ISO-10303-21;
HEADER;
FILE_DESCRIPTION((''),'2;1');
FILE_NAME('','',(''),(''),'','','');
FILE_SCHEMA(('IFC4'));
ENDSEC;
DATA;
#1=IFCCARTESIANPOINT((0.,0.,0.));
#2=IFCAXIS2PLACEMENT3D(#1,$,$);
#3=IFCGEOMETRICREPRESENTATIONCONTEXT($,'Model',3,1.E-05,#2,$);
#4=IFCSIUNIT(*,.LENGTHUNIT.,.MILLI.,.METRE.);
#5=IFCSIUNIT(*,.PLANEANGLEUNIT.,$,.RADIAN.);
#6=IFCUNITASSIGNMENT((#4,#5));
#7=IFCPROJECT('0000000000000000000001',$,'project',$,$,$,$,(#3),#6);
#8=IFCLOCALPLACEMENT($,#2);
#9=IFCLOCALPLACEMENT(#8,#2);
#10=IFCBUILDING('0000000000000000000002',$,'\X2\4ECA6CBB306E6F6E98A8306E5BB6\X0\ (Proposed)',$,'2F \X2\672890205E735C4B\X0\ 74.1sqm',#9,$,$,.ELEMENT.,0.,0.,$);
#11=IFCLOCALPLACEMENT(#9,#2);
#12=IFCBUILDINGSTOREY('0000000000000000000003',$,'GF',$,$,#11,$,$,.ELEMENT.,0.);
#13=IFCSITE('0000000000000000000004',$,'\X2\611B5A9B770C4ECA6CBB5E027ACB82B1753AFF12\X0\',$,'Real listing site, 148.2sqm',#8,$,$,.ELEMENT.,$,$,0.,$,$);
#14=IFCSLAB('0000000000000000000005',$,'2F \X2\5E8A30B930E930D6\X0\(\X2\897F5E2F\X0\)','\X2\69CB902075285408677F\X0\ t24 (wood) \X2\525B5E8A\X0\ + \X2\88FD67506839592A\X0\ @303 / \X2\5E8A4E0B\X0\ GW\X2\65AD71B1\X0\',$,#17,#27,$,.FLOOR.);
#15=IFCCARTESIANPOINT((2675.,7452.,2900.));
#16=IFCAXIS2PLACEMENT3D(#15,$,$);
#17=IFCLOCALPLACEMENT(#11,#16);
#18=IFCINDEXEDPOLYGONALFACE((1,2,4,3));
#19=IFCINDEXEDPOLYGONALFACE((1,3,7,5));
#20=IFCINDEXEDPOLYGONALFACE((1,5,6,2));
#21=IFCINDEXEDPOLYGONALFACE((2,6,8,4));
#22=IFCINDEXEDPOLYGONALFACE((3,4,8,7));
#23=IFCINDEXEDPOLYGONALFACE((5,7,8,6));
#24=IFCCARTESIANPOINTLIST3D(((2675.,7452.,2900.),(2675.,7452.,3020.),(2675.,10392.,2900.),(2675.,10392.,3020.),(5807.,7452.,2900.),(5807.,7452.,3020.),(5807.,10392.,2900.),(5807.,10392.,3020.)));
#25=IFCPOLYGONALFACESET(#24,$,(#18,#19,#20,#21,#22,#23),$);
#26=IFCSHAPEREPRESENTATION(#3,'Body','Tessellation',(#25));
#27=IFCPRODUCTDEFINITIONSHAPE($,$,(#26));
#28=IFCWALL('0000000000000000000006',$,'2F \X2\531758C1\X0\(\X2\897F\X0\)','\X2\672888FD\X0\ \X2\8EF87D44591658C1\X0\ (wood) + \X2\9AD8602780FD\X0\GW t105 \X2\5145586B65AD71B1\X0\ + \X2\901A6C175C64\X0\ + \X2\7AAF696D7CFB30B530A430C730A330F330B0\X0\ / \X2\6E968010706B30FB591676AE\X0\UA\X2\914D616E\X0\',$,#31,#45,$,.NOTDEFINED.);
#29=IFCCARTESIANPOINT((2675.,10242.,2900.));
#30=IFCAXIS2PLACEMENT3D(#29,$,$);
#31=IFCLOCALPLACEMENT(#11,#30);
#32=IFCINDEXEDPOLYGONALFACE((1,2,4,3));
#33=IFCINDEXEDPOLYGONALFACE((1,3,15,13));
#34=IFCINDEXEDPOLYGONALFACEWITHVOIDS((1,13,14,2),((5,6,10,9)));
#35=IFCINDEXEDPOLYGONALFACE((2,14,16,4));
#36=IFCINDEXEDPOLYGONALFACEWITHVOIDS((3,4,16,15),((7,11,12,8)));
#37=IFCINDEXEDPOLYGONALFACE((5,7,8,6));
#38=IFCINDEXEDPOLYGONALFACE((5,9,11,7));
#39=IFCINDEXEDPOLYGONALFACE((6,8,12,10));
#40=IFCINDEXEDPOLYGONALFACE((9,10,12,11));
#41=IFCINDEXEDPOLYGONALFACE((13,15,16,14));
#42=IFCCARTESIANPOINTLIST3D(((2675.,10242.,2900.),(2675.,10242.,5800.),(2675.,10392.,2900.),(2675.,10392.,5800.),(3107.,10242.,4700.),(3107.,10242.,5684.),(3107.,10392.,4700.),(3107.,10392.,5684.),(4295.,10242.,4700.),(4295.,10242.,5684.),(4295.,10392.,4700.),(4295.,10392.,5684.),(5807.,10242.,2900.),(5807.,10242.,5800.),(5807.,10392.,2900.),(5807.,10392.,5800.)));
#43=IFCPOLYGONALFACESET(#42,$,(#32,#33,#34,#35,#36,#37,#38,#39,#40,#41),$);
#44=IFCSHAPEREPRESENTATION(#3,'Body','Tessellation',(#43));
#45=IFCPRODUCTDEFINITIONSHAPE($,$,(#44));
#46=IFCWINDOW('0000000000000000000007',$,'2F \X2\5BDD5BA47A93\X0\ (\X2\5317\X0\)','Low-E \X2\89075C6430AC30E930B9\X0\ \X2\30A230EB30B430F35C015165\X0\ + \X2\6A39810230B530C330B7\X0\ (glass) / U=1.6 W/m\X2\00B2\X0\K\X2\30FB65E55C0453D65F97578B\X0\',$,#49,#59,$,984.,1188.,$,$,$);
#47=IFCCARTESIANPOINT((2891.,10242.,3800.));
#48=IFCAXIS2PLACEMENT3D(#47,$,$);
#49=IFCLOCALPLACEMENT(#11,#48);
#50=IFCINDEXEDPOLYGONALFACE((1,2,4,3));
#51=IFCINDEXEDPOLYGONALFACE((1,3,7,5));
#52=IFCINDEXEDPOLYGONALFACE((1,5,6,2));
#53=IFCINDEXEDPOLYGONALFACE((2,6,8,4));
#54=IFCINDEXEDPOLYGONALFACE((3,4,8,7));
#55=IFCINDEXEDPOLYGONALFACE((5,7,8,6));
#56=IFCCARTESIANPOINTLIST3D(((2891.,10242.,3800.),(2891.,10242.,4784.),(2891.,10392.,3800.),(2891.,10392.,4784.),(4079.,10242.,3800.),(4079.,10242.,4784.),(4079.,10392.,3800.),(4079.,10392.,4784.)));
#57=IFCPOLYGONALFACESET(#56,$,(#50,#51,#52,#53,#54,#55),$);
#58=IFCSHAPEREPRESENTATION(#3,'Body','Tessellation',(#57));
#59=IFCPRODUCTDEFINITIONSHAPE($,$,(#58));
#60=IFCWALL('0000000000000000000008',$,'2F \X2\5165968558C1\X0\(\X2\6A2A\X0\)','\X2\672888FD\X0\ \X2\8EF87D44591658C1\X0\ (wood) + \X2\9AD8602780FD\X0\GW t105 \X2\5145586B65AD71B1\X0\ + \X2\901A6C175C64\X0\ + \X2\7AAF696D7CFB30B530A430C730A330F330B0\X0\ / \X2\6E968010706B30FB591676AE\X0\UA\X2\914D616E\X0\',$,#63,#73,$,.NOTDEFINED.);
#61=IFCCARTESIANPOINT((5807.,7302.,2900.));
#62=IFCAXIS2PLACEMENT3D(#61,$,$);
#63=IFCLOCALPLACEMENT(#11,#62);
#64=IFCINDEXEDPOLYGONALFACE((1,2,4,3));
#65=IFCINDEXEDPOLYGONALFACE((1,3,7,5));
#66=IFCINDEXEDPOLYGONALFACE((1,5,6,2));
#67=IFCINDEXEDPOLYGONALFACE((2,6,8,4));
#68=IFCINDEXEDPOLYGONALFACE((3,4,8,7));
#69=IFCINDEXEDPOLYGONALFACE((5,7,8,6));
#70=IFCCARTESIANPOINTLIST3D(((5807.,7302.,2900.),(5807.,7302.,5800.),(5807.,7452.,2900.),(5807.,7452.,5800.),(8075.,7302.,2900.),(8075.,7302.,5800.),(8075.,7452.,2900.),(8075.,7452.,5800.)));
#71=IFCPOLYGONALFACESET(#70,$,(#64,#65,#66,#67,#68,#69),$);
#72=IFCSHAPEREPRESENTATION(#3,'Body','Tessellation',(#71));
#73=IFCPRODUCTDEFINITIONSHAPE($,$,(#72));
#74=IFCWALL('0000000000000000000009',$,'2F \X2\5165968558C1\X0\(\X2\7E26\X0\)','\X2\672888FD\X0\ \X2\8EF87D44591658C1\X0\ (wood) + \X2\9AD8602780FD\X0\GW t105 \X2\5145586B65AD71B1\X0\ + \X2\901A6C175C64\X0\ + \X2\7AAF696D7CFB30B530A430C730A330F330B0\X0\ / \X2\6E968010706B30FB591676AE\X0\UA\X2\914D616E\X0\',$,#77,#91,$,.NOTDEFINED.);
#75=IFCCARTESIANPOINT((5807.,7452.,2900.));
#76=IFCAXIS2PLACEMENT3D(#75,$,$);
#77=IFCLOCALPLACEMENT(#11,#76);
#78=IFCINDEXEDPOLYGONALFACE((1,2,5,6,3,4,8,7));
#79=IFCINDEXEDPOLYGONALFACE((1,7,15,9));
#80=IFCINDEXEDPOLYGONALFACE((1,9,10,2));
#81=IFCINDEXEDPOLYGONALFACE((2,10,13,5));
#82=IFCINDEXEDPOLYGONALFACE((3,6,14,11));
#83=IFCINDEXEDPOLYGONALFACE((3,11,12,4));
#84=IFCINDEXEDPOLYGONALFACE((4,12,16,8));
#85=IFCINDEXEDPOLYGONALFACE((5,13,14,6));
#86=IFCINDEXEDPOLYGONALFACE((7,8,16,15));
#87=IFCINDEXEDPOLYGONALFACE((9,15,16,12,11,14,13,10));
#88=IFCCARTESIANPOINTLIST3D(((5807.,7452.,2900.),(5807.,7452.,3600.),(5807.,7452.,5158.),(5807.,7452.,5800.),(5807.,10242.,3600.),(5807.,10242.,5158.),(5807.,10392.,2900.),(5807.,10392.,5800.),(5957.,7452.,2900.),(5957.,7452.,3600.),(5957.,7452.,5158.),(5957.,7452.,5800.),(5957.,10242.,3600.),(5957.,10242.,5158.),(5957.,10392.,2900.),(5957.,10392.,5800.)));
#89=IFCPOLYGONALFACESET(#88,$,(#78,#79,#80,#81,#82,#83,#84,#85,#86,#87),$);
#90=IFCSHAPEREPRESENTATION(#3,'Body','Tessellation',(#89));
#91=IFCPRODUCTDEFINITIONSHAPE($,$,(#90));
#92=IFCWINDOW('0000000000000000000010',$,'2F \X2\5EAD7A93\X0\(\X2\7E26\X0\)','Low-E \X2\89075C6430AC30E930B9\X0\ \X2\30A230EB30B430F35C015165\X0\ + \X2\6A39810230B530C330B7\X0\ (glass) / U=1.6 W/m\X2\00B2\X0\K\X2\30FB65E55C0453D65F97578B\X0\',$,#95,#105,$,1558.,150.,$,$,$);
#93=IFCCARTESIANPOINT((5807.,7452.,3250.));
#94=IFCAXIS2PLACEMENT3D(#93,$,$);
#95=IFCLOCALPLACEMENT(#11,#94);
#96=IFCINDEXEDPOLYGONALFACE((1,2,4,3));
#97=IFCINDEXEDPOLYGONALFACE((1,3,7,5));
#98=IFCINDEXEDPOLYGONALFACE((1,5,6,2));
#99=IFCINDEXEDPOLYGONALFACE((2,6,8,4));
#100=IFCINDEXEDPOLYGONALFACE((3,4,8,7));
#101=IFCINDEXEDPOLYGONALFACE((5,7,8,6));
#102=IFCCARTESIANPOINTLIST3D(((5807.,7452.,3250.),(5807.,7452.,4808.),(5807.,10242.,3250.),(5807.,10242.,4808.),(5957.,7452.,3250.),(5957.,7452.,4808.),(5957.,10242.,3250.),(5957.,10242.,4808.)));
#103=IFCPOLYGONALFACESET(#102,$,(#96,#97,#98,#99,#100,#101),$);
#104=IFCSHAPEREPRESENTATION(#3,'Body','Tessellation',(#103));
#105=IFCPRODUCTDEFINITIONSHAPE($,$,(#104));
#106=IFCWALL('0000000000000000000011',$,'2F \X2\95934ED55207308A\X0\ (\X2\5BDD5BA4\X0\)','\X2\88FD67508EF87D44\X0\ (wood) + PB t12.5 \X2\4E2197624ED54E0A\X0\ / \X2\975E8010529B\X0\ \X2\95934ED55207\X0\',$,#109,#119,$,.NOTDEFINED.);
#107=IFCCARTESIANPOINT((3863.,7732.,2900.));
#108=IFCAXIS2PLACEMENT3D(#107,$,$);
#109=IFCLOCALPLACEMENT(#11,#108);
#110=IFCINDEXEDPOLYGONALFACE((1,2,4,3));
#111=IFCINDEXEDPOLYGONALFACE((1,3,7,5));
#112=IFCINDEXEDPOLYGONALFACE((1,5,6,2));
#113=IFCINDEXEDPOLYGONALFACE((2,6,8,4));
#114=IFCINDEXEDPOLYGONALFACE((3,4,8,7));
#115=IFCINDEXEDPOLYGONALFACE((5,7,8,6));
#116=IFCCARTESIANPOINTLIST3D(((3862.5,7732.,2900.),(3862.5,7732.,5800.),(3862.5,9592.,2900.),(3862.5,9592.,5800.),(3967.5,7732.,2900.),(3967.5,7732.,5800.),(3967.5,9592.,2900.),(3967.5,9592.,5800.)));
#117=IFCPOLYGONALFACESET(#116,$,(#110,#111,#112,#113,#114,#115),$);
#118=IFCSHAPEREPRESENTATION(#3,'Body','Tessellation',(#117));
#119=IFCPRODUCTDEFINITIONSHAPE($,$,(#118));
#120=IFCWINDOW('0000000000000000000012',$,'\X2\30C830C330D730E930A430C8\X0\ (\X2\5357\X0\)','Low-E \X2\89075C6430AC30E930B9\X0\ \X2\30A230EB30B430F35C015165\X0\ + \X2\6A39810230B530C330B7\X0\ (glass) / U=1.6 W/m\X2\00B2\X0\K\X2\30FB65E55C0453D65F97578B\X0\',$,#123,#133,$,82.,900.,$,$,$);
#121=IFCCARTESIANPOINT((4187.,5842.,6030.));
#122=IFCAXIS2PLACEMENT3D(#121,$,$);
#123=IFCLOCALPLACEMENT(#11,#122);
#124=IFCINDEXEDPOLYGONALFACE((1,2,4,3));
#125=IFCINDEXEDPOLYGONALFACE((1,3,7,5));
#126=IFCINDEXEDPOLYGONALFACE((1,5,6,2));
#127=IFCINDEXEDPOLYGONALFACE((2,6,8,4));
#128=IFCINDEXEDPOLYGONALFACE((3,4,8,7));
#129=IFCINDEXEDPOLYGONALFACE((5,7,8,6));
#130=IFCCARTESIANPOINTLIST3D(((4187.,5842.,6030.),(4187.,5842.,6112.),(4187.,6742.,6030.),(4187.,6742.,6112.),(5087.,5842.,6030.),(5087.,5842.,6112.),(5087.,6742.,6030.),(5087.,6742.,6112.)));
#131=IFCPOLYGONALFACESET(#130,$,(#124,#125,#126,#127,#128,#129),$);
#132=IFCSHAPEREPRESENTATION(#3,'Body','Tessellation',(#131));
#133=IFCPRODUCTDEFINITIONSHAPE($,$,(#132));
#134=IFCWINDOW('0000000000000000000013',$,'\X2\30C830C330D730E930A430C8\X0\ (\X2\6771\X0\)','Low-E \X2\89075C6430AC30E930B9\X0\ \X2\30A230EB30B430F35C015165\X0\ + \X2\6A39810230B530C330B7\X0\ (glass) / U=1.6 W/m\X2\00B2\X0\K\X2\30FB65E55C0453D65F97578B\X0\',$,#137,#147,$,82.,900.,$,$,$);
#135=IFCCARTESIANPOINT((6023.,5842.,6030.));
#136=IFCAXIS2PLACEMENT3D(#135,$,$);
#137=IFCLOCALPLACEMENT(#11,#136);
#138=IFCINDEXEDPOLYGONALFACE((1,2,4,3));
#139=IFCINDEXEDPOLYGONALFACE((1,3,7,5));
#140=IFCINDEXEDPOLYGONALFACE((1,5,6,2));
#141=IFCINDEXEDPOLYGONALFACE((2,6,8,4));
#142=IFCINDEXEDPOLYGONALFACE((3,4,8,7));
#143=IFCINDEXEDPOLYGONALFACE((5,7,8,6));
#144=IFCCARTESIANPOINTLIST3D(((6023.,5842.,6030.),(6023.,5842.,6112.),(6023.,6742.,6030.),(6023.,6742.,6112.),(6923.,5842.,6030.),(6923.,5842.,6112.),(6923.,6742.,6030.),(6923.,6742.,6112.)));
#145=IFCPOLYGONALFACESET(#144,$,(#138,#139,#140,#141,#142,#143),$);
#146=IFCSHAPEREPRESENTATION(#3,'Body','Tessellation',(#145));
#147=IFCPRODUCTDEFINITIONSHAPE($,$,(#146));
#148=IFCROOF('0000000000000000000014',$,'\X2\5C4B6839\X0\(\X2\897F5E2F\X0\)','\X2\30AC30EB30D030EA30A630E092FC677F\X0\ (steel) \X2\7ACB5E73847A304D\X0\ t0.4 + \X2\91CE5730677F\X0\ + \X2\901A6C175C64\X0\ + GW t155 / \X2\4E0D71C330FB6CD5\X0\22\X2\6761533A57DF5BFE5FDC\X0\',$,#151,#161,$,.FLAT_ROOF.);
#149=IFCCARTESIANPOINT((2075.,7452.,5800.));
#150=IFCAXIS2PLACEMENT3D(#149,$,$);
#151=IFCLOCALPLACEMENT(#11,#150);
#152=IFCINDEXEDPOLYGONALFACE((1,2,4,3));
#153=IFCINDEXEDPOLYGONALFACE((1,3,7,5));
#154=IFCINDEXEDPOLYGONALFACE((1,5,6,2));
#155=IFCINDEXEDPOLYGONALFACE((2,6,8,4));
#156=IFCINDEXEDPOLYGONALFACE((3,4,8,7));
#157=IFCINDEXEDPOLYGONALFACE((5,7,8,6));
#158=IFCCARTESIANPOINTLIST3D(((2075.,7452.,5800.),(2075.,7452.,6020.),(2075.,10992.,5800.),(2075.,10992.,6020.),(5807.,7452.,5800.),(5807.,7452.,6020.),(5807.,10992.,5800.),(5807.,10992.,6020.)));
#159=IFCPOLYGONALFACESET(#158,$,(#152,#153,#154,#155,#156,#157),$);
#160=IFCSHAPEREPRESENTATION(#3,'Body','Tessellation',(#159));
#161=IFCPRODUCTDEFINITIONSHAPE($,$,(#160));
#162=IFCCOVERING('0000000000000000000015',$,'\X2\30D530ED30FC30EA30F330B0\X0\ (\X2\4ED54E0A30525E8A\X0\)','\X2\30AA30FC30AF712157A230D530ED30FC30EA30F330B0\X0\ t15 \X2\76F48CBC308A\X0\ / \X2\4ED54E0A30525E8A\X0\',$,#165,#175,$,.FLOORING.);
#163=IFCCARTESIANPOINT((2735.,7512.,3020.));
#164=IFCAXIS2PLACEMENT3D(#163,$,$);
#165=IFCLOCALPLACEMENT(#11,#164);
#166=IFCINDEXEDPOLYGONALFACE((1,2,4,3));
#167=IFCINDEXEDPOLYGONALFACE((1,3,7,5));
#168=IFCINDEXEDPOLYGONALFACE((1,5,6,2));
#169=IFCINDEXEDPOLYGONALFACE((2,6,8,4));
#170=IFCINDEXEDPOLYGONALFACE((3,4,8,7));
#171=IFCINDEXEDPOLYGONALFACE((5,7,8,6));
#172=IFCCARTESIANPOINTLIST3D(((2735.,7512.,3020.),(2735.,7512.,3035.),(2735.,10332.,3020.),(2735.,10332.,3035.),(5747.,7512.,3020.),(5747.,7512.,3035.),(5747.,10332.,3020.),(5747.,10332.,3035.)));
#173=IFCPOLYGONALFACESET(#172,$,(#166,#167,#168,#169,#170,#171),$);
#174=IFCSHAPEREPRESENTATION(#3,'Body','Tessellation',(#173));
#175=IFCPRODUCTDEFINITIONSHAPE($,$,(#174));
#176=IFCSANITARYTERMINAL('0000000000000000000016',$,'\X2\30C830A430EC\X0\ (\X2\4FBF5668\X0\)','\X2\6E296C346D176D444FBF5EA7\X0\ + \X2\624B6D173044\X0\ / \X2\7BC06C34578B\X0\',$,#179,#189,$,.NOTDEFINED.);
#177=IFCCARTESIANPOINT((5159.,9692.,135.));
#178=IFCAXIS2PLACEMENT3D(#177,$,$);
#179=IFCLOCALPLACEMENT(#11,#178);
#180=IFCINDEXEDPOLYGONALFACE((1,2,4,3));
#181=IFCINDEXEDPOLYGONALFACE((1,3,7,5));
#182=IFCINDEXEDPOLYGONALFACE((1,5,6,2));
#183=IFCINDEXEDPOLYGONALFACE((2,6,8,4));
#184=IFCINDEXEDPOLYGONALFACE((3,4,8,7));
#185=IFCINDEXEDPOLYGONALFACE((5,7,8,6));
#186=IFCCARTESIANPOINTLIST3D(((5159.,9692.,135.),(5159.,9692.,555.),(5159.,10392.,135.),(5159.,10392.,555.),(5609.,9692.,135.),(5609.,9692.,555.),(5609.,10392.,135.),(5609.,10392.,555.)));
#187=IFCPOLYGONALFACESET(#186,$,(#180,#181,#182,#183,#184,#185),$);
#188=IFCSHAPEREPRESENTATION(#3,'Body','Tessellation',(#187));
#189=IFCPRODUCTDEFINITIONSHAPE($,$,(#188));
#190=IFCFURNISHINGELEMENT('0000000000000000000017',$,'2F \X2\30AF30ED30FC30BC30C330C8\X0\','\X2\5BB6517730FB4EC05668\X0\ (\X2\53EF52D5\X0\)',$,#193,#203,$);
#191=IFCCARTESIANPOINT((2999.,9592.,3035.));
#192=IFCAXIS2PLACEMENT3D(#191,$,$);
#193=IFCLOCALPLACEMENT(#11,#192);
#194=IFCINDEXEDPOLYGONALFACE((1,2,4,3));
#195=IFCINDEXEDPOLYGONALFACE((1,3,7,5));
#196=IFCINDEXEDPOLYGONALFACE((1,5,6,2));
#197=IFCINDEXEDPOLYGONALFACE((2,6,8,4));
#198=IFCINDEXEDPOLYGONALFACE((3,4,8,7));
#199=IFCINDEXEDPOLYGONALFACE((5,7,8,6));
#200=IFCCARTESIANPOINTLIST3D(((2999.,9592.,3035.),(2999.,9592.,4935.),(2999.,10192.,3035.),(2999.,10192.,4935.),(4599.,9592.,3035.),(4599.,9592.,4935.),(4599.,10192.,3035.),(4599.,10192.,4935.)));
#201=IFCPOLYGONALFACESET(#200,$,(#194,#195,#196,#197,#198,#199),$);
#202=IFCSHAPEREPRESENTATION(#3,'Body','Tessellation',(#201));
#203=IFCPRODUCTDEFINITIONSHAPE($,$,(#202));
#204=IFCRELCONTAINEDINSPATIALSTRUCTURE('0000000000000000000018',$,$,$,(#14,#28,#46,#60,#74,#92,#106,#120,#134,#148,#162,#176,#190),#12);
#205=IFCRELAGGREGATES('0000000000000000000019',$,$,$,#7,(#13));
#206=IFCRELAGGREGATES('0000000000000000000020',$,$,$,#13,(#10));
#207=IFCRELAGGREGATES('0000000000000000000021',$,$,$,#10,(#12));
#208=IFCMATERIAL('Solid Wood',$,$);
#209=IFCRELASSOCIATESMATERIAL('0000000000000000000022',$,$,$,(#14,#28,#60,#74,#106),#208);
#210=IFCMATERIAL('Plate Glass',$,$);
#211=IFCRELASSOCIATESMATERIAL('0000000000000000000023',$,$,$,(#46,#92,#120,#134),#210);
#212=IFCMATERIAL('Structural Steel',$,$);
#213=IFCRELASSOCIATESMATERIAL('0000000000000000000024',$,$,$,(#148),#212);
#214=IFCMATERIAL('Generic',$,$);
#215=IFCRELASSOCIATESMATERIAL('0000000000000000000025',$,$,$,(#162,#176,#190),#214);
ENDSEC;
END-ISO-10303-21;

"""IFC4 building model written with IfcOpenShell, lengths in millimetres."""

from ifc_helpers import new_model, si_unit, frame, frame_2d, origin, place, context, project, spatial, rectangle, extrude, material, element, fill, save


model = new_model("IFC4")

# Units and contexts
model_context = context("Model", 3, precision=1e-05, world=origin())
ifc_project = project(units=[si_unit("LENGTHUNIT", "METRE", prefix="MILLI"), si_unit("PLANEANGLEUNIT", "RADIAN")], contexts=[model_context])

# Site, building, storey
site_placement = place(None, origin())
site = spatial("IfcSite", under=ifc_project, at=site_placement, Name="愛媛県今治市立花町２", ObjectType="Real listing site, 148.2sqm", CompositionType="ELEMENT", RefElevation=0.0)
building_placement = place(site_placement, origin())
building = spatial("IfcBuilding", under=site, at=building_placement, Name="今治の潮風の家 (Proposed)", ObjectType="2F 木造平屋 74.1sqm", CompositionType="ELEMENT", ElevationOfRefHeight=0.0, ElevationOfTerrain=0.0)
storey_placement = place(building_placement, origin())
storey = spatial("IfcBuildingStorey", under=building, at=storey_placement, Name="GF", CompositionType="ELEMENT", Elevation=0.0)

# Slab
ifc_material_1 = material(Name="Solid Wood")
slab_placement = place(storey_placement, frame((2675.0, 7452.0, 2900.0)))
element("IfcSlab", 1, at=slab_placement, inside=storey, material=ifc_material_1, Name="2F 床スラブ(西帯)", Description="構造用合板 t24 (wood) 剛床 + 製材根太 @303 / 床下 GW断熱", PredefinedType="FLOOR", context=model_context, shape_type="SweptSolid", body=[
    extrude(rectangle(XDim=3132.0, YDim=2940.0, at=frame_2d((1566.0, 1470.0))), frame((2675.0, 7452.0, 2900.0)), (0.0, 0.0, 1.0), 120.0),
])

# Wall, opening, window
wall_1_placement = place(storey_placement, frame((2675.0, 10242.0, 2900.0)))
wall_1 = element("IfcWall", 2, at=wall_1_placement, inside=storey, material=ifc_material_1, Name="2F 北壁(西)", Description="木製 軸組外壁 (wood) + 高性能GW t105 充填断熱 + 通気層 + 窯業系サイディング / 準耐火・外皮UA配慮", PredefinedType="NOTDEFINED", context=model_context, shape_type="SweptSolid", body=[
    extrude(rectangle(XDim=3132.0, YDim=150.0, at=frame_2d((1566.0, 75.0))), frame((2675.0, 10242.0, 2900.0)), (0.0, 0.0, 1.0), 2900.0),
])
opening_1_placement = place(storey_placement, frame((2891.0, 10242.0, 3800.0)))
opening_1 = element("IfcOpeningElement", 3, at=opening_1_placement, cuts=wall_1, PredefinedType="NOTDEFINED", context=model_context, shape_type="SweptSolid", body=[
    extrude(rectangle(XDim=1188.0, YDim=150.0, at=frame_2d((594.0, 75.0))), frame((2891.0, 10242.0, 3800.0)), (0.0, 0.0, 1.0), 984.0),
])
ifc_material_2 = material(Name="Plate Glass")
window_1_placement = place(storey_placement, frame((2891.0, 10242.0, 3800.0)))
window_1 = element("IfcWindow", 4, at=window_1_placement, inside=storey, material=ifc_material_2, Name="2F 寝室窓 (北)", Description="Low-E 複層ガラス アルゴン封入 + 樹脂サッシ (glass) / U=1.6 W/m²K・日射取得型", OverallHeight=984.0, OverallWidth=1188.0, context=model_context, shape_type="SweptSolid", body=[
    extrude(rectangle(XDim=1188.0, YDim=150.0, at=frame_2d((594.0, 75.0))), frame((2891.0, 10242.0, 3800.0)), (0.0, 0.0, 1.0), 984.0),
])
fill(opening_1, window_1)

# Wall
wall_2_placement = place(storey_placement, frame((5807.0, 7302.0, 2900.0)))
element("IfcWall", 5, at=wall_2_placement, inside=storey, material=ifc_material_1, Name="2F 入隅壁(横)", Description="木製 軸組外壁 (wood) + 高性能GW t105 充填断熱 + 通気層 + 窯業系サイディング / 準耐火・外皮UA配慮", PredefinedType="NOTDEFINED", context=model_context, shape_type="SweptSolid", body=[
    extrude(rectangle(XDim=2268.0, YDim=150.0, at=frame_2d((1134.0, 75.0))), frame((5807.0, 7302.0, 2900.0)), (0.0, 0.0, 1.0), 2900.0),
])

# Wall, opening, window
wall_3_placement = place(storey_placement, frame((5807.0, 7452.0, 2900.0)))
wall_3 = element("IfcWall", 6, at=wall_3_placement, inside=storey, material=ifc_material_1, Name="2F 入隅壁(縦)", Description="木製 軸組外壁 (wood) + 高性能GW t105 充填断熱 + 通気層 + 窯業系サイディング / 準耐火・外皮UA配慮", PredefinedType="NOTDEFINED", context=model_context, shape_type="SweptSolid", body=[
    extrude(rectangle(XDim=150.0, YDim=2940.0, at=frame_2d((75.0, 1470.0))), frame((5807.0, 7452.0, 2900.0)), (0.0, 0.0, 1.0), 2900.0),
])
opening_2_placement = place(storey_placement, frame((5807.0, 7452.0, 3250.0)))
opening_2 = element("IfcOpeningElement", 7, at=opening_2_placement, cuts=wall_3, PredefinedType="NOTDEFINED", context=model_context, shape_type="SweptSolid", body=[
    extrude(rectangle(XDim=150.0, YDim=2790.0, at=frame_2d((75.0, 1395.0))), frame((5807.0, 7452.0, 3250.0)), (0.0, 0.0, 1.0), 1558.0),
])
window_2_placement = place(storey_placement, frame((5807.0, 7452.0, 3250.0)))
window_2 = element("IfcWindow", 8, at=window_2_placement, inside=storey, material=ifc_material_2, Name="2F 庭窓(縦)", Description="Low-E 複層ガラス アルゴン封入 + 樹脂サッシ (glass) / U=1.6 W/m²K・日射取得型", OverallHeight=1558.0, OverallWidth=150.0, context=model_context, shape_type="SweptSolid", body=[
    extrude(rectangle(XDim=150.0, YDim=2790.0, at=frame_2d((75.0, 1395.0))), frame((5807.0, 7452.0, 3250.0)), (0.0, 0.0, 1.0), 1558.0),
])
fill(opening_2, window_2)

# Wall
wall_4_placement = place(storey_placement, frame((3863.0, 7732.0, 2900.0)))
element("IfcWall", 9, at=wall_4_placement, inside=storey, material=ifc_material_1, Name="2F 間仕切り (寝室)", Description="製材軸組 (wood) + PB t12.5 両面仕上 / 非耐力 間仕切", PredefinedType="NOTDEFINED", context=model_context, shape_type="SweptSolid", body=[
    extrude(rectangle(XDim=105.0, YDim=1860.0, at=frame_2d((52.0, 930.0))), frame((3863.0, 7732.0, 2900.0)), (0.0, 0.0, 1.0), 2900.0),
])

# Windows
window_3_placement = place(storey_placement, frame((4187.0, 5842.0, 6030.0)))
element("IfcWindow", 10, at=window_3_placement, inside=storey, material=ifc_material_2, Name="トップライト (南)", Description="Low-E 複層ガラス アルゴン封入 + 樹脂サッシ (glass) / U=1.6 W/m²K・日射取得型", OverallHeight=82.0, OverallWidth=900.0, context=model_context, shape_type="SweptSolid", body=[
    extrude(rectangle(XDim=900.0, YDim=900.0, at=frame_2d((450.0, 450.0))), frame((4187.0, 5842.0, 6030.0)), (0.0, 0.0, 1.0), 82.0),
])
window_4_placement = place(storey_placement, frame((6023.0, 5842.0, 6030.0)))
element("IfcWindow", 11, at=window_4_placement, inside=storey, material=ifc_material_2, Name="トップライト (東)", Description="Low-E 複層ガラス アルゴン封入 + 樹脂サッシ (glass) / U=1.6 W/m²K・日射取得型", OverallHeight=82.0, OverallWidth=900.0, context=model_context, shape_type="SweptSolid", body=[
    extrude(rectangle(XDim=900.0, YDim=900.0, at=frame_2d((450.0, 450.0))), frame((6023.0, 5842.0, 6030.0)), (0.0, 0.0, 1.0), 82.0),
])

# Roof
ifc_material_3 = material(Name="Structural Steel")
for number, where, name in (
    (12, (2075.0, 7452.0, 5800.0), "屋根(西帯)"),
):
    element("IfcRoof", number, at=place(storey_placement, frame(where)), inside=storey, material=ifc_material_3, Name=name, Description="ガルバリウム鋼板 (steel) 立平葺き t0.4 + 野地板 + 通気層 + GW t155 / 不燃・法22条区域対応", PredefinedType="FLAT_ROOF", context=model_context, shape_type="SweptSolid", body=[
        extrude(rectangle(XDim=3732.0, YDim=3540.0, at=frame_2d((1866.0, 1770.0))), frame((2075.0, 7452.0, 5800.0)), (0.0, 0.0, 1.0), 220.0),
    ])

# Covering
ifc_material_4 = material(Name="Generic")
covering_placement = place(storey_placement, frame((2735.0, 7512.0, 3020.0)))
element("IfcCovering", 13, at=covering_placement, inside=storey, material=ifc_material_4, Name="フローリング (仕上げ床)", Description="オーク無垢フローリング t15 直貼り / 仕上げ床", PredefinedType="FLOORING", context=model_context, shape_type="SweptSolid", body=[
    extrude(rectangle(XDim=3012.0, YDim=2820.0, at=frame_2d((1506.0, 1410.0))), frame((2735.0, 7512.0, 3020.0)), (0.0, 0.0, 1.0), 15.0),
])

# Sanitary terminal
sanitary_terminal_placement = place(storey_placement, frame((5159.0, 9692.0, 135.0)))
element("IfcSanitaryTerminal", 14, at=sanitary_terminal_placement, inside=storey, material=ifc_material_4, Name="トイレ (便器)", Description="温水洗浄便座 + 手洗い / 節水型", PredefinedType="NOTDEFINED", context=model_context, shape_type="SweptSolid", body=[
    extrude(rectangle(XDim=450.0, YDim=700.0, at=frame_2d((225.0, 350.0))), frame((5159.0, 9692.0, 135.0)), (0.0, 0.0, 1.0), 420.0),
])

# Furnishing element
furnishing_1_placement = place(storey_placement, frame((2999.0, 9592.0, 3035.0)))
element("IfcFurnishingElement", 15, at=furnishing_1_placement, inside=storey, material=ifc_material_4, Name="2F クローゼット", Description="家具・什器 (可動)", context=model_context, shape_type="SweptSolid", body=[
    extrude(rectangle(XDim=1600.0, YDim=600.0, at=frame_2d((800.0, 300.0))), frame((2999.0, 9592.0, 3035.0)), (0.0, 0.0, 1.0), 1900.0),
])

save(model, "model.ifc")
